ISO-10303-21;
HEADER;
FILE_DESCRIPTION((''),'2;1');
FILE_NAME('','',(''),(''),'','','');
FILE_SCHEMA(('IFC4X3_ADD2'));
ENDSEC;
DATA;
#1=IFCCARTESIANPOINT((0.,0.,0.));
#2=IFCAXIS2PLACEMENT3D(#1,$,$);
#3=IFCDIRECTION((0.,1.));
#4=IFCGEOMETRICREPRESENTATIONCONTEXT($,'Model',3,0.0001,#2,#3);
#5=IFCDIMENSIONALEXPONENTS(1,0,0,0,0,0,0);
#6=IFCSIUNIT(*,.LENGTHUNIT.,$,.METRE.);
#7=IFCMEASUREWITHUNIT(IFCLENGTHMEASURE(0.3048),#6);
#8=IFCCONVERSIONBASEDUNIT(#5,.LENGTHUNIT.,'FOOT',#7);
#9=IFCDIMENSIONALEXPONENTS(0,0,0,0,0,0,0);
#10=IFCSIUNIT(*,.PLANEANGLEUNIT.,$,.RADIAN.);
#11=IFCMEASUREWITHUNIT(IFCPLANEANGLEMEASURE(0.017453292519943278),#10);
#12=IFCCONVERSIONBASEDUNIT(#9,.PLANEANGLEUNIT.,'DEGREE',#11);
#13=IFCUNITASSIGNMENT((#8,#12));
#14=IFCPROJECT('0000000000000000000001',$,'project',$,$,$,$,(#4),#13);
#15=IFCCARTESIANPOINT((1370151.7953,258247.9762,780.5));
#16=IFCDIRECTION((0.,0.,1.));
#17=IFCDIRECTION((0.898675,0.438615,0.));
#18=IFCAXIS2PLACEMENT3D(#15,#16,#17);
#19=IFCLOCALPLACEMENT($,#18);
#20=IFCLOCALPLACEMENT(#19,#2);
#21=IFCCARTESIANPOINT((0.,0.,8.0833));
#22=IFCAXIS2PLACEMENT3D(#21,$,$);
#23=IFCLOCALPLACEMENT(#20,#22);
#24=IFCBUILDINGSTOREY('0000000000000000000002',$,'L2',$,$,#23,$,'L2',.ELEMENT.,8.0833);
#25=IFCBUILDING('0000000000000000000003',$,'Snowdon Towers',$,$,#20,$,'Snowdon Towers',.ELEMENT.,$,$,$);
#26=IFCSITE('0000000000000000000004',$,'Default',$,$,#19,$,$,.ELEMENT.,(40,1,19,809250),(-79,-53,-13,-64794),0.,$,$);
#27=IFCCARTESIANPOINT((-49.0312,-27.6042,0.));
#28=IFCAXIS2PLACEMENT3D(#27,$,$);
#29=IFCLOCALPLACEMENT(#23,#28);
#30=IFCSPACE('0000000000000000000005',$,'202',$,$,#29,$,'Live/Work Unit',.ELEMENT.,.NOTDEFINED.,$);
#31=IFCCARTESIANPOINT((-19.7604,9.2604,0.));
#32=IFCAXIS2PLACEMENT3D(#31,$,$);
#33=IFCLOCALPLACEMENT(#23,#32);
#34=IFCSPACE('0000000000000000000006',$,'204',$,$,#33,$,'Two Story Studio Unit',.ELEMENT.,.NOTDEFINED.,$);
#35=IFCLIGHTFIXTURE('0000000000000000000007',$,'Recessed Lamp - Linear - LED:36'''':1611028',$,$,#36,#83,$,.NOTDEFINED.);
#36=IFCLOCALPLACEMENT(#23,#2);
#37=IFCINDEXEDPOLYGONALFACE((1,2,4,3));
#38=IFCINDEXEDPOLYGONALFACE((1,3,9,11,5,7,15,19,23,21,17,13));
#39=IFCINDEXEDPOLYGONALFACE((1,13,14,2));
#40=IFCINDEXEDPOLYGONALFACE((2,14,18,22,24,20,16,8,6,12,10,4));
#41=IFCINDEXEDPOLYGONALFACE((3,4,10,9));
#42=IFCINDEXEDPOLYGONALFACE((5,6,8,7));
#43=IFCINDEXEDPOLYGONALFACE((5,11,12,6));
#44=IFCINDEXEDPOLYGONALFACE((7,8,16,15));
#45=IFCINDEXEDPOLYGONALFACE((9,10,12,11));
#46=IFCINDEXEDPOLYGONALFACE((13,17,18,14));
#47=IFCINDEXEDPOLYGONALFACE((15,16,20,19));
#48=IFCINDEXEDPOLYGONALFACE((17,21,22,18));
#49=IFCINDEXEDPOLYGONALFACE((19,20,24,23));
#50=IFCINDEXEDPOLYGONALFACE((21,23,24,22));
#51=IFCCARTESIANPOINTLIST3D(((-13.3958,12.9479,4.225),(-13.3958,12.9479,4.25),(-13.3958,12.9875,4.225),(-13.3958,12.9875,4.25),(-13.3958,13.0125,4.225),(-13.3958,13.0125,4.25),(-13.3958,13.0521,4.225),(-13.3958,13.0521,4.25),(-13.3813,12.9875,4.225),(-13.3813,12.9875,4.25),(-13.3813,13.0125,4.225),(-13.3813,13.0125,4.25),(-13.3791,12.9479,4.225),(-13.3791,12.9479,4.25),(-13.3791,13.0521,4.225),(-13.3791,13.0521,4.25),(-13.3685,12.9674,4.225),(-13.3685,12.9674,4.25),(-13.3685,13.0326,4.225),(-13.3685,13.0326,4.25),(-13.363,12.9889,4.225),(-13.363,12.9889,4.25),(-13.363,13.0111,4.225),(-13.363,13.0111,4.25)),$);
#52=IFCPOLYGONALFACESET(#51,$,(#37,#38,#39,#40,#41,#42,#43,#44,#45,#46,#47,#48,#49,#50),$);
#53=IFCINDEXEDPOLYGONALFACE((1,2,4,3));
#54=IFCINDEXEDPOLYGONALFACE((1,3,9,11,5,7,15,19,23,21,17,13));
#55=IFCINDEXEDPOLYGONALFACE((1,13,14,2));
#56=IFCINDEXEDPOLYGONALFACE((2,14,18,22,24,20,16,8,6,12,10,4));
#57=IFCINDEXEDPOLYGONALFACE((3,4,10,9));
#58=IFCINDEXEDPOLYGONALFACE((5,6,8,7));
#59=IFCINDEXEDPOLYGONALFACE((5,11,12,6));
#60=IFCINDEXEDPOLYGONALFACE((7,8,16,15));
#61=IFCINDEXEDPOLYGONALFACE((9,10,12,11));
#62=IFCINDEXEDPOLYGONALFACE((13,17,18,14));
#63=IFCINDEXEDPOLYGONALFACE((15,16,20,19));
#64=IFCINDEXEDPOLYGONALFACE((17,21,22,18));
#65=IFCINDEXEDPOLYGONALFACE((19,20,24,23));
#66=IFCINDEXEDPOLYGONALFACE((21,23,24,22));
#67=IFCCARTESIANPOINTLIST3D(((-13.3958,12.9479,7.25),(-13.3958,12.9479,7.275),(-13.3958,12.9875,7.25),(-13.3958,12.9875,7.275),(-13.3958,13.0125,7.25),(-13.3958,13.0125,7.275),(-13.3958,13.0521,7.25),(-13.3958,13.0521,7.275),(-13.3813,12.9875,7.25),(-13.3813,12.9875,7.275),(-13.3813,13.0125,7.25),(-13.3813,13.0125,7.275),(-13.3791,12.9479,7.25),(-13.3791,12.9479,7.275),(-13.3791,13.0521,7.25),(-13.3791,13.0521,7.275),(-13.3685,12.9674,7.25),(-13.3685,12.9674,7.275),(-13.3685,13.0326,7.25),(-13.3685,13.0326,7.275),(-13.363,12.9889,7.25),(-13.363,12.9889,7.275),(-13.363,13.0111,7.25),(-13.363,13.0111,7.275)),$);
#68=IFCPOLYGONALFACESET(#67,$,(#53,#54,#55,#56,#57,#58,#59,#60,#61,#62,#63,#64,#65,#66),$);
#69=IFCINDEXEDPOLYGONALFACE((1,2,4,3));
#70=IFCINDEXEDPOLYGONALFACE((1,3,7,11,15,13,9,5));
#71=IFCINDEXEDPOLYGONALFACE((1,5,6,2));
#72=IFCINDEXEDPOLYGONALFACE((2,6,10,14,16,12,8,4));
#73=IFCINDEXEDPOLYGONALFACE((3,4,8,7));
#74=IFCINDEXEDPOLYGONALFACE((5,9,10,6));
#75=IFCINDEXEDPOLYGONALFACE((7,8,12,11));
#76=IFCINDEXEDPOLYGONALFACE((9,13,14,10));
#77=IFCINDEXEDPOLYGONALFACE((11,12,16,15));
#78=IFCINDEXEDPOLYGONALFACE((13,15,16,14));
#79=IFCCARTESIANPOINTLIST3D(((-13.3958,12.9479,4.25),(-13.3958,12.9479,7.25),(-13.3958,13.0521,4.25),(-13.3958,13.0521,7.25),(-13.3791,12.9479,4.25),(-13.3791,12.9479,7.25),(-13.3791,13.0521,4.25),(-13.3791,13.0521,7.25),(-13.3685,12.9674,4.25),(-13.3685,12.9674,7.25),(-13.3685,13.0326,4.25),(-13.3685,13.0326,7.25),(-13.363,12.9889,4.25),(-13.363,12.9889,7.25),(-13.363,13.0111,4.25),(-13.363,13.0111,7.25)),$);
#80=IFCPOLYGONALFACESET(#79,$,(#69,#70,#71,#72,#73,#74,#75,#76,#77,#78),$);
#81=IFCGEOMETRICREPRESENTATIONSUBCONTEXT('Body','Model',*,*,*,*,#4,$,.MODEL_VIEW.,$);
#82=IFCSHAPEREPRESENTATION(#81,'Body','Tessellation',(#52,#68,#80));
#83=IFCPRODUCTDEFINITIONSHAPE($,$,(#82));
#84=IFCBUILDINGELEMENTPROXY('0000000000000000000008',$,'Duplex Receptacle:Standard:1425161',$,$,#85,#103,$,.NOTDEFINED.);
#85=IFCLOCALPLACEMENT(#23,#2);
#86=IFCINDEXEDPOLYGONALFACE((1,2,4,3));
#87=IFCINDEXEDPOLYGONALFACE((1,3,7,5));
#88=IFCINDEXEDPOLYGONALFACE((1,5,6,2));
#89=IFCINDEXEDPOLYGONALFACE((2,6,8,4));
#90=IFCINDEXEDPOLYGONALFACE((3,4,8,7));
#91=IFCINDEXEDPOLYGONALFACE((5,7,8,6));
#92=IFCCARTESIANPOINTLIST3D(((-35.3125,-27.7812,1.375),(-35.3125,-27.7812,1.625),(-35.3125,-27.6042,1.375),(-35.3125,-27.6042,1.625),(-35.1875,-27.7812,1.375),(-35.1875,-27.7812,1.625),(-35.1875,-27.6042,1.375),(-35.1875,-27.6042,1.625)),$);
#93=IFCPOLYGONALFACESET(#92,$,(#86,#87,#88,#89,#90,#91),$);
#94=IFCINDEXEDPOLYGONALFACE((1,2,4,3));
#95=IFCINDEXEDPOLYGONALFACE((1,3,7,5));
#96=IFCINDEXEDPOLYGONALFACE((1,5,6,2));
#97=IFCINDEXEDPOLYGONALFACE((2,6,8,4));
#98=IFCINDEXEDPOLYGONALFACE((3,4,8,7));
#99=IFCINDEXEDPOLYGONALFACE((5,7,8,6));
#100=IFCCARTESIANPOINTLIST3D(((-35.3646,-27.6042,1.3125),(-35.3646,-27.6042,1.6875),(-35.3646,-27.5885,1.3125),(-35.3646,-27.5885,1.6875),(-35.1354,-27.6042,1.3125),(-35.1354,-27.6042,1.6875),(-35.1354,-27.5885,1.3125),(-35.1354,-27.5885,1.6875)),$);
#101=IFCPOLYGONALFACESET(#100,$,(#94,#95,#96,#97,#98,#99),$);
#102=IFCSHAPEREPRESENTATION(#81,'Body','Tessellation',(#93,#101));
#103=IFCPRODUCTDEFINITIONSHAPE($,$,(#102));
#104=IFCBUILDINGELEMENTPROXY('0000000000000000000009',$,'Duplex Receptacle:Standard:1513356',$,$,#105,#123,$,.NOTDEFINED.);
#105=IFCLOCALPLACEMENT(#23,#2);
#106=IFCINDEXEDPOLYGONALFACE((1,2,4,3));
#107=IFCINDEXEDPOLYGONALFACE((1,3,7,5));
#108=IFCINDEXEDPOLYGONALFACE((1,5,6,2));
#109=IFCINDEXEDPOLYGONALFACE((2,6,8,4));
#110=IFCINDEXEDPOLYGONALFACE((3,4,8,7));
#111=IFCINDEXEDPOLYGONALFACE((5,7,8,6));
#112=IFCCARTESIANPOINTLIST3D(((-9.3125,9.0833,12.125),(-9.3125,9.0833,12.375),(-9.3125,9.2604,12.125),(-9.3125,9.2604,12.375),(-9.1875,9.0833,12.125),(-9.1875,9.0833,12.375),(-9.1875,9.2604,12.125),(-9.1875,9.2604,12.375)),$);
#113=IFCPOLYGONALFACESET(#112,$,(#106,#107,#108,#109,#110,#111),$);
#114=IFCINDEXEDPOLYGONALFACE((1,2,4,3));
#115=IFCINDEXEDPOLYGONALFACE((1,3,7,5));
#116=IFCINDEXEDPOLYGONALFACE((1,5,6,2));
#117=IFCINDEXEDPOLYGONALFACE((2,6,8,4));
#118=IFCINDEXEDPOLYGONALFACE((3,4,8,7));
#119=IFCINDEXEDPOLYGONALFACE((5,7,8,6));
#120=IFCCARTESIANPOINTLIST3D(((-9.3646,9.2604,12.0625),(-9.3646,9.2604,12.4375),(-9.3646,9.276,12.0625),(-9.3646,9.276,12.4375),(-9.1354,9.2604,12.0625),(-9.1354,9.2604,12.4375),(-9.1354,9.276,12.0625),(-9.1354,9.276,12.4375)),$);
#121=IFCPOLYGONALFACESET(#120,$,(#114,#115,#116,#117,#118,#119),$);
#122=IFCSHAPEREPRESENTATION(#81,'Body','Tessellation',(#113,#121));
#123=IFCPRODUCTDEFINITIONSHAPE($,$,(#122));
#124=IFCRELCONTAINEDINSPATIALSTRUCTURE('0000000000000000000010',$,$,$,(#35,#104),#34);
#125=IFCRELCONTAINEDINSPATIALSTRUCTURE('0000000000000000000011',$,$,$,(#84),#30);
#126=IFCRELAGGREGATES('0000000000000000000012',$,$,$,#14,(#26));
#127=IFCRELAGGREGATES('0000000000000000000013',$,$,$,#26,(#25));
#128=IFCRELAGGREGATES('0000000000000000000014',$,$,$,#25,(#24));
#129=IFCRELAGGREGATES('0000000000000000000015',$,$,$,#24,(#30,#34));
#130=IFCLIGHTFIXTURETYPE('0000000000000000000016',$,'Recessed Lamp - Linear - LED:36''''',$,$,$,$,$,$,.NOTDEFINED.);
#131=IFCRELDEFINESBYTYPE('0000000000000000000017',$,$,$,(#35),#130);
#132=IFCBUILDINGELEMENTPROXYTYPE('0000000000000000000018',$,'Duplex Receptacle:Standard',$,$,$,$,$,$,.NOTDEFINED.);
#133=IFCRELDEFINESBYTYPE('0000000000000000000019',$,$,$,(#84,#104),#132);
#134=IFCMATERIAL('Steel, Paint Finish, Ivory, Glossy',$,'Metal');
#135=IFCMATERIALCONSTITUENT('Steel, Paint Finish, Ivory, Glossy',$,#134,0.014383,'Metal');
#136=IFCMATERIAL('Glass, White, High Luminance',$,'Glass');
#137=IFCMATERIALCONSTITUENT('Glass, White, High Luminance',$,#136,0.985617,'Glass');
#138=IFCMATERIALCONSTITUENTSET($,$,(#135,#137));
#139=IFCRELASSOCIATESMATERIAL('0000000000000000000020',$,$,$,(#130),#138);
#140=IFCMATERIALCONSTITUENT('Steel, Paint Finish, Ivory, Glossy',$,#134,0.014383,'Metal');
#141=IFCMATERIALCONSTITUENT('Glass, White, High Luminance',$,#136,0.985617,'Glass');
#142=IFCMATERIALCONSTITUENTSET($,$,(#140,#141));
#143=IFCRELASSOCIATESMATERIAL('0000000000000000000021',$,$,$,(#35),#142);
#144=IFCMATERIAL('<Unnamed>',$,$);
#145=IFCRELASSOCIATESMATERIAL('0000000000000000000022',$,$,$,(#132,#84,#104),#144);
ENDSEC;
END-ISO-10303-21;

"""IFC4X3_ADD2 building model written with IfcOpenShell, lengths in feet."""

from ifc_helpers import new_model, entity, si_unit, converted_unit, direction, frame, frame_2d, origin, origin_2d_with_axis, place, context, subcontext, project, spatial, polyline, circle_curve, parameter, trimmed, segment, composite_curve, rectangle, outline, extrude, source, transform, mapped, material, constituent, constituent_set, type_object, type_shapes, element, save


model = new_model("IFC4X3_ADD2")

# Units and contexts
model_context = context("Model", 3, precision=0.0001, world=origin(), true_north=direction((0.0, 1.0)))
body_context = subcontext(model_context, "Body", "Model", "MODEL_VIEW")
ifc_project = project(units=[converted_unit("LENGTHUNIT", "FOOT", entity("IfcLengthMeasure", 0.3048), si_unit("LENGTHUNIT", "METRE"), dimensions=[1, 0, 0, 0, 0, 0, 0]), converted_unit("PLANEANGLEUNIT", "DEGREE", entity("IfcPlaneAngleMeasure", 0.017453292519943278), si_unit("PLANEANGLEUNIT", "RADIAN"), dimensions=[0, 0, 0, 0, 0, 0, 0])], contexts=[model_context])

# Site, building, storey, space
site_placement = place(None, frame((1370151.7953, 258247.9762, 780.5), z_axis=(0.0, 0.0, 1.0), x_axis=(0.898675, 0.438615, 0.0)))
site = spatial("IfcSite", under=ifc_project, at=site_placement, Name="Default", CompositionType="ELEMENT", RefLatitude=(40, 1, 19, 809250), RefLongitude=(-79, -53, -13, -64794), RefElevation=0.0)
building_placement = place(site_placement, origin())
building = spatial("IfcBuilding", under=site, at=building_placement, Name="Snowdon Towers", LongName="Snowdon Towers", CompositionType="ELEMENT")
storey_placement = place(building_placement, frame((0.0, 0.0, 8.0833)))
storey = spatial("IfcBuildingStorey", under=building, at=storey_placement, Name="L2", LongName="L2", CompositionType="ELEMENT", Elevation=8.0833)
space_1_placement = place(storey_placement, frame((-49.0312, -27.6042, 0.0)))
space_1 = spatial("IfcSpace", under=storey, at=space_1_placement, Name="202", LongName="Live/Work Unit", CompositionType="ELEMENT", PredefinedType="NOTDEFINED")

# Shared definitions
ifc_material_1 = material(Name="<Unnamed>")

# Shared definitions
space_2_placement = place(storey_placement, frame((-19.7604, 9.2604, 0.0)))
space_2 = spatial("IfcSpace", under=storey, at=space_2_placement, Name="204", LongName="Two Story Studio Unit", CompositionType="ELEMENT", PredefinedType="NOTDEFINED")

# Light fixture
ifc_material_2 = material(Name="Glass, White, High Luminance", Category="Glass")
ifc_material_3 = material(Name="Steel, Paint Finish, Ivory, Glossy", Category="Metal")
ifc_constituent_1 = constituent(ifc_material_3, Name="Steel, Paint Finish, Ivory, Glossy", Category="Metal", fraction=0.014383)
ifc_constituent_2 = constituent(ifc_material_2, Name="Glass, White, High Luminance", Category="Glass", fraction=0.985617)
ifc_constituent_set_1 = constituent_set(constituents=[ifc_constituent_1, ifc_constituent_2])
light_fixture_type_1 = type_object("IfcLightFixtureType", Name="Recessed Lamp - Linear - LED:36''", PredefinedType="NOTDEFINED", material=ifc_constituent_set_1)
shared_shape_1 = source(origin(), body_context, "Body", "SweptSolid", [
    extrude(outline(composite_curve([segment(trimmed(circle_curve(frame_2d((0.0, -0.0633), x_axis=(1.0, 0.0)), 0.089), [parameter(54.196986)], [parameter(125.803014)], True, "PARAMETER"), True, "CONTINUOUS"), segment(polyline([(-0.0521, 0.0089), (-0.0521, -0.0078)]), True, "CONTINUOUS"), segment(polyline([(-0.0521, -0.0078), (-0.0125, -0.0078)]), True, "CONTINUOUS"), segment(polyline([(-0.0125, -0.0078), (-0.0125, 0.0068)]), True, "CONTINUOUS"), segment(polyline([(-0.0125, 0.0068), (0.0125, 0.0068)]), True, "CONTINUOUS"), segment(polyline([(0.0125, 0.0068), (0.0125, -0.0078)]), True, "CONTINUOUS"), segment(polyline([(0.0125, -0.0078), (0.0521, -0.0078)]), True, "CONTINUOUS"), segment(polyline([(0.0521, -0.0078), (0.0521, 0.0089)]), True, "CONTINUOUS")], self_intersect=False)), frame((-1.525, 0.0, 0.0078), z_axis=(1.0, 0.0, 0.0), x_axis=(0.0, 1.0, 0.0)), (0.0, 0.0, 1.0), 0.025),
    extrude(outline(composite_curve([segment(trimmed(circle_curve(frame_2d((0.0, -0.0633), x_axis=(1.0, 0.0)), 0.089), [parameter(54.196986)], [parameter(125.803014)], True, "PARAMETER"), True, "CONTINUOUS"), segment(polyline([(-0.0521, 0.0089), (-0.0521, -0.0078)]), True, "CONTINUOUS"), segment(polyline([(-0.0521, -0.0078), (-0.0125, -0.0078)]), True, "CONTINUOUS"), segment(polyline([(-0.0125, -0.0078), (-0.0125, 0.0068)]), True, "CONTINUOUS"), segment(polyline([(-0.0125, 0.0068), (0.0125, 0.0068)]), True, "CONTINUOUS"), segment(polyline([(0.0125, 0.0068), (0.0125, -0.0078)]), True, "CONTINUOUS"), segment(polyline([(0.0125, -0.0078), (0.0521, -0.0078)]), True, "CONTINUOUS"), segment(polyline([(0.0521, -0.0078), (0.0521, 0.0089)]), True, "CONTINUOUS")], self_intersect=False)), frame((1.5, 0.0, 0.0078), z_axis=(1.0, 0.0, 0.0), x_axis=(0.0, 1.0, 0.0)), (0.0, 0.0, 1.0), 0.025),
    extrude(outline(composite_curve([segment(trimmed(circle_curve(frame_2d((0.0, -0.0639), x_axis=(1.0, 0.0)), 0.089), [parameter(54.196986)], [parameter(125.803014)], True, "PARAMETER"), True, "CONTINUOUS"), segment(polyline([(-0.0521, 0.0083), (-0.0521, -0.0083)]), True, "CONTINUOUS"), segment(polyline([(-0.0521, -0.0083), (0.0521, -0.0083)]), True, "CONTINUOUS"), segment(polyline([(0.0521, -0.0083), (0.0521, 0.0083)]), True, "CONTINUOUS")], self_intersect=False)), frame((-1.5, 0.0, 0.0083), z_axis=(1.0, 0.0, 0.0), x_axis=(0.0, 1.0, 0.0)), (0.0, 0.0, 1.0), 3.0),
])
type_shapes(light_fixture_type_1, [shared_shape_1])
ifc_constituent_3 = constituent(ifc_material_3, Name="Steel, Paint Finish, Ivory, Glossy", Category="Metal", fraction=0.014383)
ifc_constituent_4 = constituent(ifc_material_2, Name="Glass, White, High Luminance", Category="Glass", fraction=0.985617)
ifc_constituent_set_2 = constituent_set(constituents=[ifc_constituent_3, ifc_constituent_4])
light_fixture_1_placement = place(space_2_placement, frame((6.3646, 3.7396, 5.75), z_axis=(1.0, 0.0, 0.0), x_axis=(0.0, 0.0, 1.0)))
element("IfcLightFixture", 1, at=light_fixture_1_placement, inside=space_2, type_object=light_fixture_type_1, material=ifc_constituent_set_2, Name="Recessed Lamp - Linear - LED:36'':1611028", PredefinedType="NOTDEFINED", context=body_context, shape_type="MappedRepresentation", body=[
    mapped(shared_shape_1, transform((0.0, 0.0, 0.0), scale=1.0)),
])

# Building element proxy
building_element_proxy_type_1 = type_object("IfcBuildingElementProxyType", Name="Duplex Receptacle:Standard", PredefinedType="NOTDEFINED", material=ifc_material_1)
shared_shape_2 = source(origin(), body_context, "Body", "SweptSolid", [
    extrude(rectangle(XDim=0.125, YDim=0.25, at=origin_2d_with_axis()), frame((0.0, 0.0, -0.1771), z_axis=(0.0, 0.0, 1.0), x_axis=(-1.0, 0.0, 0.0)), (0.0, 0.0, 1.0), 0.1771),
    extrude(rectangle(XDim=0.2292, YDim=0.375, at=frame_2d((0.0, 0.0), x_axis=(1.0, 0.0))), frame((0.0, 0.0, 0.0), z_axis=(0.0, 0.0, 1.0), x_axis=(-1.0, 0.0, 0.0)), (0.0, 0.0, 1.0), 0.0156),
])
type_shapes(building_element_proxy_type_1, [shared_shape_2])
for number, where, z_axis, x_axis, name in (
    (2, (13.7812, 0.0, 1.5), (0.0, 1.0, 0.0), (-1.0, 0.0, 0.0), "Duplex Receptacle:Standard:1425161"),
):
    element("IfcBuildingElementProxy", number, at=place(space_1_placement, frame(where, z_axis=z_axis, x_axis=x_axis)), inside=space_1, type_object=building_element_proxy_type_1, material=ifc_material_1, Name=name, PredefinedType="NOTDEFINED", context=body_context, shape_type="MappedRepresentation", body=[
        mapped(shared_shape_2, transform((0.0, 0.0, 0.0), scale=1.0)),
    ])

# Building element proxy
for number, where, z_axis, x_axis, name in (
    (3, (10.5104, 0.0, 12.25), (0.0, 1.0, 0.0), (-1.0, 0.0, 0.0), "Duplex Receptacle:Standard:1513356"),
):
    element("IfcBuildingElementProxy", number, at=place(space_2_placement, frame(where, z_axis=z_axis, x_axis=x_axis)), inside=space_2, type_object=building_element_proxy_type_1, material=ifc_material_1, Name=name, PredefinedType="NOTDEFINED", context=body_context, shape_type="MappedRepresentation", body=[
        mapped(shared_shape_2, transform((0.0, 0.0, 0.0), scale=1.0)),
    ])

save(model, "model.ifc")
